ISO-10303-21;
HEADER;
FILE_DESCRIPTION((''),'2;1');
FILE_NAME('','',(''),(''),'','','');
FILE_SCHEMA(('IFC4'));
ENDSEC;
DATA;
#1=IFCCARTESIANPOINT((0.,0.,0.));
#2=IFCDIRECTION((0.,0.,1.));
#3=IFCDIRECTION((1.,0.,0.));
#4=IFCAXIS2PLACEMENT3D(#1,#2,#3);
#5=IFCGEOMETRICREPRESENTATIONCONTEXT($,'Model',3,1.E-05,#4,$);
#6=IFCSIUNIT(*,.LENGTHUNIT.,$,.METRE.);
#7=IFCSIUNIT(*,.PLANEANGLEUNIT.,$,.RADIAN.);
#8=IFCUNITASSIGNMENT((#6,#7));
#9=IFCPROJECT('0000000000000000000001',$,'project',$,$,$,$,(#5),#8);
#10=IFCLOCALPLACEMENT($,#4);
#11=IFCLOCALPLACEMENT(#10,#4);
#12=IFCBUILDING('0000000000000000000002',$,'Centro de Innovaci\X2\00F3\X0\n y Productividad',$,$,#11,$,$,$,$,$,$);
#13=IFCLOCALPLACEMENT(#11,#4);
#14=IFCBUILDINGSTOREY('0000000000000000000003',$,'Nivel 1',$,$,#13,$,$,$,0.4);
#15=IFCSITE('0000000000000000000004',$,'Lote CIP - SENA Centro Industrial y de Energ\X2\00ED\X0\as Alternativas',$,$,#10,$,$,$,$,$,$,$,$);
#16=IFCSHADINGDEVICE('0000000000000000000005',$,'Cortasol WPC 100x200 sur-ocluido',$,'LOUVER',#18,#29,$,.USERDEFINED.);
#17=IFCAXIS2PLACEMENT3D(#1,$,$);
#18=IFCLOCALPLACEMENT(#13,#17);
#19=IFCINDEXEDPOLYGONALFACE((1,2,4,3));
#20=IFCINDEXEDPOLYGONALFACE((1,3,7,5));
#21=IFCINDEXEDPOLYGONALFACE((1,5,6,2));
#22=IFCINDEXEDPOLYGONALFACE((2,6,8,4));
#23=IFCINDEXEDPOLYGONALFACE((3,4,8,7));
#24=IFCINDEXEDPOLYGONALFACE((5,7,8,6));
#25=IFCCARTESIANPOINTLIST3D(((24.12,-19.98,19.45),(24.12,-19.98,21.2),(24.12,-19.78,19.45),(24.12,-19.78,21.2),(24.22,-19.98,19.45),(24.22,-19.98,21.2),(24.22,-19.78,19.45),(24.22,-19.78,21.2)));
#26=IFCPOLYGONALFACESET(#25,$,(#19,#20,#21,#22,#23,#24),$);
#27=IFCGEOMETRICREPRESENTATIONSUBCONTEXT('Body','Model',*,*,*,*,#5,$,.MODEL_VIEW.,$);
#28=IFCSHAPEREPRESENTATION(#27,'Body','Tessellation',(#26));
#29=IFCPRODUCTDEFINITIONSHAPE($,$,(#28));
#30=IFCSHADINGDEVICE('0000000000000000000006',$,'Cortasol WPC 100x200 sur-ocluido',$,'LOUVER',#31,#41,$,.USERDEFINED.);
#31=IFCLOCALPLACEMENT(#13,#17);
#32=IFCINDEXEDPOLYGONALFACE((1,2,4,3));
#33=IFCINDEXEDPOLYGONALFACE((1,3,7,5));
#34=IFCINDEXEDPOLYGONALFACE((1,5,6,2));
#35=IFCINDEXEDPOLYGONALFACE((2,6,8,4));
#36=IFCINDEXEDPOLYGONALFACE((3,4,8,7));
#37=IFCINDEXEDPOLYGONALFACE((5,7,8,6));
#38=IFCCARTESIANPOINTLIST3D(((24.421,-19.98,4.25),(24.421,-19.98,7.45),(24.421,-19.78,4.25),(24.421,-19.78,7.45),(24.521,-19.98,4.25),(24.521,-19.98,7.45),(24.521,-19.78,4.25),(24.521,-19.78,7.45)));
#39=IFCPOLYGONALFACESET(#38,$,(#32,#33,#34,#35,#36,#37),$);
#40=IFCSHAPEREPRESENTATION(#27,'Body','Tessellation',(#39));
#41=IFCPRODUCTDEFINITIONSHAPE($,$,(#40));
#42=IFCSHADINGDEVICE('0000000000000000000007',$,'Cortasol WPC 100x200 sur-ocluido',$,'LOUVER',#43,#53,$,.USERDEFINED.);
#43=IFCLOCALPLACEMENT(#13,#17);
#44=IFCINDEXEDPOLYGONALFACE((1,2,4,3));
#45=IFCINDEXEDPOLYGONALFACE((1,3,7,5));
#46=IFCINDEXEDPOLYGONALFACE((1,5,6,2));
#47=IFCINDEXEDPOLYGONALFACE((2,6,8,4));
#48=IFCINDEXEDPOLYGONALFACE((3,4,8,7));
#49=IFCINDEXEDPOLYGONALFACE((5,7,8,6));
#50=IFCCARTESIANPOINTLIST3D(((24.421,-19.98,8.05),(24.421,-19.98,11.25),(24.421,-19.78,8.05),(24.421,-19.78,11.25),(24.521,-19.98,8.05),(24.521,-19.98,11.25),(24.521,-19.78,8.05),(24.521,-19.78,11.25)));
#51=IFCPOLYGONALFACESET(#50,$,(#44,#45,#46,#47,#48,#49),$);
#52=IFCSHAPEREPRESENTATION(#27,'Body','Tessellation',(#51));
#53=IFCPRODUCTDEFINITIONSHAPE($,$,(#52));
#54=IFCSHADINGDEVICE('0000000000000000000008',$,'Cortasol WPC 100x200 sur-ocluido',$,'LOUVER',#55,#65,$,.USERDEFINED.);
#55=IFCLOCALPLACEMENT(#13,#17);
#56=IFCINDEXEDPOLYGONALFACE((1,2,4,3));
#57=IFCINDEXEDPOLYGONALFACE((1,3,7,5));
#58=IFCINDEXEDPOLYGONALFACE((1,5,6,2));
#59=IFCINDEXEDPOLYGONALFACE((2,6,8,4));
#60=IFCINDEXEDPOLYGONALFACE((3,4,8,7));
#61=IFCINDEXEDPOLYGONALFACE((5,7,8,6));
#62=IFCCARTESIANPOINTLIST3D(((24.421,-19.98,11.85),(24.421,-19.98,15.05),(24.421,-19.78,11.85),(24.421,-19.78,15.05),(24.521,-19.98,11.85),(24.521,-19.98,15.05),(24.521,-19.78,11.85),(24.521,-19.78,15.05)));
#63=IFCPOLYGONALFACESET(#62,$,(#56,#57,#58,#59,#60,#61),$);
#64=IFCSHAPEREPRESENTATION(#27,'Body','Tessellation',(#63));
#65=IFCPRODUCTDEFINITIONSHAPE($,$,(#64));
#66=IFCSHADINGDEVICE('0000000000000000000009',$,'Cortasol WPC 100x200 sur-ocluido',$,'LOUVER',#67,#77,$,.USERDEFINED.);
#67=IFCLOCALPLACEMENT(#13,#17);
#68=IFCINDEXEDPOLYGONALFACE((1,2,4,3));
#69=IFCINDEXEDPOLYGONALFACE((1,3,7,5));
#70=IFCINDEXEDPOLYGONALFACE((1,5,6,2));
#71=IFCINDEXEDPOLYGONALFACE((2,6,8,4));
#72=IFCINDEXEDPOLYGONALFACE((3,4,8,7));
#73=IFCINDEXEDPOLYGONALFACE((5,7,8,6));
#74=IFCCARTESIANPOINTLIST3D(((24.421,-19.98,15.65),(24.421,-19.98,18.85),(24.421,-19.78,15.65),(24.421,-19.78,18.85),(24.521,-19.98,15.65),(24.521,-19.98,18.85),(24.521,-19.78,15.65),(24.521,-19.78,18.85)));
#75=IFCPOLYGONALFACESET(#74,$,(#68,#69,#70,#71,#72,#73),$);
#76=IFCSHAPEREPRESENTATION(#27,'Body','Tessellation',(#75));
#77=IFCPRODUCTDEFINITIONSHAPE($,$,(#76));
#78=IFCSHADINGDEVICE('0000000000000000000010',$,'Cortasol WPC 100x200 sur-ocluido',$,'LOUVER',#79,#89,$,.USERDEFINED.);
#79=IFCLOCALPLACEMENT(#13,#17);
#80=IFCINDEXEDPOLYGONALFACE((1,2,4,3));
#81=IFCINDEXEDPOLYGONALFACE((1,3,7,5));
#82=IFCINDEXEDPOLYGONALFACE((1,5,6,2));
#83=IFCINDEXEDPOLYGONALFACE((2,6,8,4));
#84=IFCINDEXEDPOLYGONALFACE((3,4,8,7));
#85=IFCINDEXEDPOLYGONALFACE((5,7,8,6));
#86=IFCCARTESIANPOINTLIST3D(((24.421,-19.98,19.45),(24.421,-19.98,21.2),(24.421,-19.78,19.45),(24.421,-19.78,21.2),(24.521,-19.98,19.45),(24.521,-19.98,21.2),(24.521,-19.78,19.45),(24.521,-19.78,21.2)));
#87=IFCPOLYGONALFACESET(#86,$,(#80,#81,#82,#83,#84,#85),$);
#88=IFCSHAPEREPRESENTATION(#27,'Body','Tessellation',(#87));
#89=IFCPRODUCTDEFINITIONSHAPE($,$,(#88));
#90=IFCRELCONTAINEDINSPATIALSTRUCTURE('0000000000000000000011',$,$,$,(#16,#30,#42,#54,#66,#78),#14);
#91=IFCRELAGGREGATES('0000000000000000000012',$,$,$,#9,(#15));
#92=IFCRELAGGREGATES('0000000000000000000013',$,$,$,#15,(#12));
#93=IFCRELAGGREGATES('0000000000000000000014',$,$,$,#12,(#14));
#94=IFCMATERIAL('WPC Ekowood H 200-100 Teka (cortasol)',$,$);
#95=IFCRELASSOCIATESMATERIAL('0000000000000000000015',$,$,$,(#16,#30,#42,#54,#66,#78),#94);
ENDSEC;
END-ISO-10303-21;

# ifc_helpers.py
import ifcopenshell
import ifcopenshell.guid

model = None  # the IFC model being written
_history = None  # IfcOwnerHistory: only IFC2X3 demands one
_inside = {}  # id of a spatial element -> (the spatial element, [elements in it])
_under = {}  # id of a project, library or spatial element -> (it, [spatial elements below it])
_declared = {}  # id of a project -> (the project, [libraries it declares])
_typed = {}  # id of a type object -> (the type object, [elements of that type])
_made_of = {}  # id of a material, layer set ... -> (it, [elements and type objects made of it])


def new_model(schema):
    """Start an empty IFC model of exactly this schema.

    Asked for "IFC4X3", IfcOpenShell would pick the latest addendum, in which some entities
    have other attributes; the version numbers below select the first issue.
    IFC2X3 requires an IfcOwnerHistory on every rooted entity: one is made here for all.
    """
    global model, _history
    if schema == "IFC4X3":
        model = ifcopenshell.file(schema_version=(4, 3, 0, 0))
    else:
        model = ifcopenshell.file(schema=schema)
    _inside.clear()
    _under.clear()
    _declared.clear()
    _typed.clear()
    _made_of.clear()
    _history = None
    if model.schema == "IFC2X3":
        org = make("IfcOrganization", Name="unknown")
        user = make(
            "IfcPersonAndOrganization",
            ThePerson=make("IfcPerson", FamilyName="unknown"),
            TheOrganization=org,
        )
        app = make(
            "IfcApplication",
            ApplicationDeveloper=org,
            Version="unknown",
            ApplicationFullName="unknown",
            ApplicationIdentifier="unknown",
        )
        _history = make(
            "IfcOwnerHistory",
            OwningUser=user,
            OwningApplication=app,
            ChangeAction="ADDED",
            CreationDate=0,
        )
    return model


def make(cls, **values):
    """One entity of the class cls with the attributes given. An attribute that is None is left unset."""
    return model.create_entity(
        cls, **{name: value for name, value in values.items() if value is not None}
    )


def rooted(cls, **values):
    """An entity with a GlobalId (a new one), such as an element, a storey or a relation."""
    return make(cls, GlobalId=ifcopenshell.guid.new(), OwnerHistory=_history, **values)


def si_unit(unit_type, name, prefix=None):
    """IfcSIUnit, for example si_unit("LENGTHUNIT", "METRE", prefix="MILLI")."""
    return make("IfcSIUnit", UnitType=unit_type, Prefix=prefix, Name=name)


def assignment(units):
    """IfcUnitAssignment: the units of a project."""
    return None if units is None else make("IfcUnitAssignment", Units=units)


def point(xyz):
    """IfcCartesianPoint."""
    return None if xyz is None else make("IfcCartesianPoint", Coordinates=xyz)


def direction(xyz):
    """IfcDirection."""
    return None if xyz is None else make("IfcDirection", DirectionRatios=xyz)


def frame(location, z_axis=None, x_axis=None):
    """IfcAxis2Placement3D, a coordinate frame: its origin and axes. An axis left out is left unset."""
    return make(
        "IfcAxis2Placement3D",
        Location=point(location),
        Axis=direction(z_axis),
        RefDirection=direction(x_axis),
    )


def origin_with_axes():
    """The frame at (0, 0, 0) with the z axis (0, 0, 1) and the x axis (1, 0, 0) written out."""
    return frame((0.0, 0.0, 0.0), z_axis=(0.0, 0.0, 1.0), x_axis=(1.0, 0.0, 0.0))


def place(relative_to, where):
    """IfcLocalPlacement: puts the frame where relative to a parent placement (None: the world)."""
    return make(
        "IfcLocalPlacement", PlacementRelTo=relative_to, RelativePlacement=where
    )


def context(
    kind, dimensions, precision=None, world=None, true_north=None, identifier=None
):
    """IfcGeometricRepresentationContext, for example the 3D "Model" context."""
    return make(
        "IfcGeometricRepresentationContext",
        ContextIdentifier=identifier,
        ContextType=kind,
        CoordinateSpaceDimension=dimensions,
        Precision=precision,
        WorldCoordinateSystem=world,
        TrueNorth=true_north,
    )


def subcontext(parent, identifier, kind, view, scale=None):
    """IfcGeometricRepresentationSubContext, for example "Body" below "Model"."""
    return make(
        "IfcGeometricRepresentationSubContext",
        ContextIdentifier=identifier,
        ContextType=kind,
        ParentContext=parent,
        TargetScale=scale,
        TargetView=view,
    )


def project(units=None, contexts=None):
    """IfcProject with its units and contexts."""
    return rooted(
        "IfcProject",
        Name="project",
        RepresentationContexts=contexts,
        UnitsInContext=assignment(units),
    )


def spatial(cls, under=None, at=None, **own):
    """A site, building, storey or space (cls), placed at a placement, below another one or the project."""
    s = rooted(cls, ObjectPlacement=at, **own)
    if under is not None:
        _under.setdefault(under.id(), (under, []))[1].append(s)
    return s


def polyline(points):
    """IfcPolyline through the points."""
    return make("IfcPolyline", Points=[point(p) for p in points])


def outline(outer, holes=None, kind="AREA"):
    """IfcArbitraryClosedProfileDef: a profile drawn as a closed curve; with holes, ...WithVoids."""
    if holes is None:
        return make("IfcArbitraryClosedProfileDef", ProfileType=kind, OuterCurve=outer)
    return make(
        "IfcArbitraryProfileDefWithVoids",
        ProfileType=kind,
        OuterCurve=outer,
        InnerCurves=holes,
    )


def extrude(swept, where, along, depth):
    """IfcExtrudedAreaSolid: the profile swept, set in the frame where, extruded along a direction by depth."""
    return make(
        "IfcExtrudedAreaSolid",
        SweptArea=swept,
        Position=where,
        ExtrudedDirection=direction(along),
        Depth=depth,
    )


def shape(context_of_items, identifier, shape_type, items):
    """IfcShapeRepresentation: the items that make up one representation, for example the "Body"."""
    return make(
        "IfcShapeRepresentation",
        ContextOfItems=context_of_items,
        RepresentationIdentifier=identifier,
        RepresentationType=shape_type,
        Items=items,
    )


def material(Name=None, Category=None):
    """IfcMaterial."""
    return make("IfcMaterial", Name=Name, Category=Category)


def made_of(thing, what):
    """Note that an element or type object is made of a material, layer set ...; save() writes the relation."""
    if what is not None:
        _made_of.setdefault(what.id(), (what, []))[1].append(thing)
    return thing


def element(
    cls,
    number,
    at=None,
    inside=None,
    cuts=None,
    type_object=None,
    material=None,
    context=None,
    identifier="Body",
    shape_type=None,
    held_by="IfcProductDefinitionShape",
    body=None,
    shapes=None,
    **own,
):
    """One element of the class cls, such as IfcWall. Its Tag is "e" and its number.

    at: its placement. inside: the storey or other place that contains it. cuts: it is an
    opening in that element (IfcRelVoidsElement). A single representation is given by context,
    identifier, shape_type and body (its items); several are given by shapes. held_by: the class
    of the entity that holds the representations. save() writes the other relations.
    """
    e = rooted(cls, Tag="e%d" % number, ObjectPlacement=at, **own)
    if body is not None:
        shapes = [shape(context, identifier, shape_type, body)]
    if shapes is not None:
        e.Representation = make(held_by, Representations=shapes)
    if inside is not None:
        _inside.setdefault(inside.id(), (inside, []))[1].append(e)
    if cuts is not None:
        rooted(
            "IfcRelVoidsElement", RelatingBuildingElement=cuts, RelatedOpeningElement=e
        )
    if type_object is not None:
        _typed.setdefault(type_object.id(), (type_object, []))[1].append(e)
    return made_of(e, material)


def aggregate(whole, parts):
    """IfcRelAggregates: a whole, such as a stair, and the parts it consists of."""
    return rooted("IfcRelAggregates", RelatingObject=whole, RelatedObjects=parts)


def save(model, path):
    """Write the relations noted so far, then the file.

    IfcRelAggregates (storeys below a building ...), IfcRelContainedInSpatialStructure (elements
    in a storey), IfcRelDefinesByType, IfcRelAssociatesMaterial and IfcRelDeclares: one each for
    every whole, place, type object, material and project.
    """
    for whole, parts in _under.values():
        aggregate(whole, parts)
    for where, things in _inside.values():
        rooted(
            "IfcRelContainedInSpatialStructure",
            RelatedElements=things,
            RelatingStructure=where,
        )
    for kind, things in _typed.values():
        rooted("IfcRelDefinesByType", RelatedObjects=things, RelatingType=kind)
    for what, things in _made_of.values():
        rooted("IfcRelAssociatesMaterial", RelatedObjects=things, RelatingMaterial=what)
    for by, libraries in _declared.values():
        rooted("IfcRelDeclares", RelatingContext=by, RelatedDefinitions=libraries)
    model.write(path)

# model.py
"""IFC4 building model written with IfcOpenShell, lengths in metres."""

from ifc_helpers import new_model, si_unit, frame, origin_with_axes, place, context, subcontext, project, spatial, polyline, outline, extrude, material, element, save


model = new_model("IFC4")

# Units and contexts
model_context = context("Model", 3, precision=1e-05, world=origin_with_axes())
body_context = subcontext(model_context, "Body", "Model", "MODEL_VIEW")
ifc_project = project(units=[si_unit("LENGTHUNIT", "METRE"), si_unit("PLANEANGLEUNIT", "RADIAN")], contexts=[model_context])

# Site, building, storey
site_placement = place(None, origin_with_axes())
site = spatial("IfcSite", under=ifc_project, at=site_placement, Name="Lote CIP - SENA Centro Industrial y de Energías Alternativas")
building_placement = place(site_placement, origin_with_axes())
building = spatial("IfcBuilding", under=site, at=building_placement, Name="Centro de Innovación y Productividad")
storey_placement = place(building_placement, origin_with_axes())
storey = spatial("IfcBuildingStorey", under=building, at=storey_placement, Name="Nivel 1", Elevation=0.4)

# Shading devices
ifc_material_1 = material(Name="WPC Ekowood H 200-100 Teka (cortasol)")
shading_device_1_placement = place(storey_placement, origin_with_axes())
element("IfcShadingDevice", 1, at=shading_device_1_placement, inside=storey, material=ifc_material_1, Name="Cortasol WPC 100x200 sur-ocluido", ObjectType="LOUVER", PredefinedType="USERDEFINED", context=body_context, shape_type="SweptSolid", body=[
    extrude(outline(polyline([(24.12, -19.98), (24.12, -19.78), (24.22, -19.78), (24.22, -19.98), (24.12, -19.98)])), frame((0.0, 0.0, 19.45)), (0.0, 0.0, 1.0), 1.75),
])
shading_device_2_placement = place(storey_placement, origin_with_axes())
element("IfcShadingDevice", 2, at=shading_device_2_placement, inside=storey, material=ifc_material_1, Name="Cortasol WPC 100x200 sur-ocluido", ObjectType="LOUVER", PredefinedType="USERDEFINED", context=body_context, shape_type="SweptSolid", body=[
    extrude(outline(polyline([(24.421, -19.98), (24.421, -19.78), (24.521, -19.78), (24.521, -19.98), (24.421, -19.98)])), frame((0.0, 0.0, 4.25)), (0.0, 0.0, 1.0), 3.2),
])
shading_device_3_placement = place(storey_placement, origin_with_axes())
element("IfcShadingDevice", 3, at=shading_device_3_placement, inside=storey, material=ifc_material_1, Name="Cortasol WPC 100x200 sur-ocluido", ObjectType="LOUVER", PredefinedType="USERDEFINED", context=body_context, shape_type="SweptSolid", body=[
    extrude(outline(polyline([(24.421, -19.98), (24.421, -19.78), (24.521, -19.78), (24.521, -19.98), (24.421, -19.98)])), frame((0.0, 0.0, 8.05)), (0.0, 0.0, 1.0), 3.2),
])
shading_device_4_placement = place(storey_placement, origin_with_axes())
element("IfcShadingDevice", 4, at=shading_device_4_placement, inside=storey, material=ifc_material_1, Name="Cortasol WPC 100x200 sur-ocluido", ObjectType="LOUVER", PredefinedType="USERDEFINED", context=body_context, shape_type="SweptSolid", body=[
    extrude(outline(polyline([(24.421, -19.98), (24.421, -19.78), (24.521, -19.78), (24.521, -19.98), (24.421, -19.98)])), frame((0.0, 0.0, 11.85)), (0.0, 0.0, 1.0), 3.2),
])
shading_device_5_placement = place(storey_placement, origin_with_axes())
element("IfcShadingDevice", 5, at=shading_device_5_placement, inside=storey, material=ifc_material_1, Name="Cortasol WPC 100x200 sur-ocluido", ObjectType="LOUVER", PredefinedType="USERDEFINED", context=body_context, shape_type="SweptSolid", body=[
    extrude(outline(polyline([(24.421, -19.98), (24.421, -19.78), (24.521, -19.78), (24.521, -19.98), (24.421, -19.98)])), frame((0.0, 0.0, 15.65)), (0.0, 0.0, 1.0), 3.2),
])
shading_device_6_placement = place(storey_placement, origin_with_axes())
element("IfcShadingDevice", 6, at=shading_device_6_placement, inside=storey, material=ifc_material_1, Name="Cortasol WPC 100x200 sur-ocluido", ObjectType="LOUVER", PredefinedType="USERDEFINED", context=body_context, shape_type="SweptSolid", body=[
    extrude(outline(polyline([(24.421, -19.98), (24.421, -19.78), (24.521, -19.78), (24.521, -19.98), (24.421, -19.98)])), frame((0.0, 0.0, 19.45)), (0.0, 0.0, 1.0), 1.75),
])

save(model, "model.ifc")
